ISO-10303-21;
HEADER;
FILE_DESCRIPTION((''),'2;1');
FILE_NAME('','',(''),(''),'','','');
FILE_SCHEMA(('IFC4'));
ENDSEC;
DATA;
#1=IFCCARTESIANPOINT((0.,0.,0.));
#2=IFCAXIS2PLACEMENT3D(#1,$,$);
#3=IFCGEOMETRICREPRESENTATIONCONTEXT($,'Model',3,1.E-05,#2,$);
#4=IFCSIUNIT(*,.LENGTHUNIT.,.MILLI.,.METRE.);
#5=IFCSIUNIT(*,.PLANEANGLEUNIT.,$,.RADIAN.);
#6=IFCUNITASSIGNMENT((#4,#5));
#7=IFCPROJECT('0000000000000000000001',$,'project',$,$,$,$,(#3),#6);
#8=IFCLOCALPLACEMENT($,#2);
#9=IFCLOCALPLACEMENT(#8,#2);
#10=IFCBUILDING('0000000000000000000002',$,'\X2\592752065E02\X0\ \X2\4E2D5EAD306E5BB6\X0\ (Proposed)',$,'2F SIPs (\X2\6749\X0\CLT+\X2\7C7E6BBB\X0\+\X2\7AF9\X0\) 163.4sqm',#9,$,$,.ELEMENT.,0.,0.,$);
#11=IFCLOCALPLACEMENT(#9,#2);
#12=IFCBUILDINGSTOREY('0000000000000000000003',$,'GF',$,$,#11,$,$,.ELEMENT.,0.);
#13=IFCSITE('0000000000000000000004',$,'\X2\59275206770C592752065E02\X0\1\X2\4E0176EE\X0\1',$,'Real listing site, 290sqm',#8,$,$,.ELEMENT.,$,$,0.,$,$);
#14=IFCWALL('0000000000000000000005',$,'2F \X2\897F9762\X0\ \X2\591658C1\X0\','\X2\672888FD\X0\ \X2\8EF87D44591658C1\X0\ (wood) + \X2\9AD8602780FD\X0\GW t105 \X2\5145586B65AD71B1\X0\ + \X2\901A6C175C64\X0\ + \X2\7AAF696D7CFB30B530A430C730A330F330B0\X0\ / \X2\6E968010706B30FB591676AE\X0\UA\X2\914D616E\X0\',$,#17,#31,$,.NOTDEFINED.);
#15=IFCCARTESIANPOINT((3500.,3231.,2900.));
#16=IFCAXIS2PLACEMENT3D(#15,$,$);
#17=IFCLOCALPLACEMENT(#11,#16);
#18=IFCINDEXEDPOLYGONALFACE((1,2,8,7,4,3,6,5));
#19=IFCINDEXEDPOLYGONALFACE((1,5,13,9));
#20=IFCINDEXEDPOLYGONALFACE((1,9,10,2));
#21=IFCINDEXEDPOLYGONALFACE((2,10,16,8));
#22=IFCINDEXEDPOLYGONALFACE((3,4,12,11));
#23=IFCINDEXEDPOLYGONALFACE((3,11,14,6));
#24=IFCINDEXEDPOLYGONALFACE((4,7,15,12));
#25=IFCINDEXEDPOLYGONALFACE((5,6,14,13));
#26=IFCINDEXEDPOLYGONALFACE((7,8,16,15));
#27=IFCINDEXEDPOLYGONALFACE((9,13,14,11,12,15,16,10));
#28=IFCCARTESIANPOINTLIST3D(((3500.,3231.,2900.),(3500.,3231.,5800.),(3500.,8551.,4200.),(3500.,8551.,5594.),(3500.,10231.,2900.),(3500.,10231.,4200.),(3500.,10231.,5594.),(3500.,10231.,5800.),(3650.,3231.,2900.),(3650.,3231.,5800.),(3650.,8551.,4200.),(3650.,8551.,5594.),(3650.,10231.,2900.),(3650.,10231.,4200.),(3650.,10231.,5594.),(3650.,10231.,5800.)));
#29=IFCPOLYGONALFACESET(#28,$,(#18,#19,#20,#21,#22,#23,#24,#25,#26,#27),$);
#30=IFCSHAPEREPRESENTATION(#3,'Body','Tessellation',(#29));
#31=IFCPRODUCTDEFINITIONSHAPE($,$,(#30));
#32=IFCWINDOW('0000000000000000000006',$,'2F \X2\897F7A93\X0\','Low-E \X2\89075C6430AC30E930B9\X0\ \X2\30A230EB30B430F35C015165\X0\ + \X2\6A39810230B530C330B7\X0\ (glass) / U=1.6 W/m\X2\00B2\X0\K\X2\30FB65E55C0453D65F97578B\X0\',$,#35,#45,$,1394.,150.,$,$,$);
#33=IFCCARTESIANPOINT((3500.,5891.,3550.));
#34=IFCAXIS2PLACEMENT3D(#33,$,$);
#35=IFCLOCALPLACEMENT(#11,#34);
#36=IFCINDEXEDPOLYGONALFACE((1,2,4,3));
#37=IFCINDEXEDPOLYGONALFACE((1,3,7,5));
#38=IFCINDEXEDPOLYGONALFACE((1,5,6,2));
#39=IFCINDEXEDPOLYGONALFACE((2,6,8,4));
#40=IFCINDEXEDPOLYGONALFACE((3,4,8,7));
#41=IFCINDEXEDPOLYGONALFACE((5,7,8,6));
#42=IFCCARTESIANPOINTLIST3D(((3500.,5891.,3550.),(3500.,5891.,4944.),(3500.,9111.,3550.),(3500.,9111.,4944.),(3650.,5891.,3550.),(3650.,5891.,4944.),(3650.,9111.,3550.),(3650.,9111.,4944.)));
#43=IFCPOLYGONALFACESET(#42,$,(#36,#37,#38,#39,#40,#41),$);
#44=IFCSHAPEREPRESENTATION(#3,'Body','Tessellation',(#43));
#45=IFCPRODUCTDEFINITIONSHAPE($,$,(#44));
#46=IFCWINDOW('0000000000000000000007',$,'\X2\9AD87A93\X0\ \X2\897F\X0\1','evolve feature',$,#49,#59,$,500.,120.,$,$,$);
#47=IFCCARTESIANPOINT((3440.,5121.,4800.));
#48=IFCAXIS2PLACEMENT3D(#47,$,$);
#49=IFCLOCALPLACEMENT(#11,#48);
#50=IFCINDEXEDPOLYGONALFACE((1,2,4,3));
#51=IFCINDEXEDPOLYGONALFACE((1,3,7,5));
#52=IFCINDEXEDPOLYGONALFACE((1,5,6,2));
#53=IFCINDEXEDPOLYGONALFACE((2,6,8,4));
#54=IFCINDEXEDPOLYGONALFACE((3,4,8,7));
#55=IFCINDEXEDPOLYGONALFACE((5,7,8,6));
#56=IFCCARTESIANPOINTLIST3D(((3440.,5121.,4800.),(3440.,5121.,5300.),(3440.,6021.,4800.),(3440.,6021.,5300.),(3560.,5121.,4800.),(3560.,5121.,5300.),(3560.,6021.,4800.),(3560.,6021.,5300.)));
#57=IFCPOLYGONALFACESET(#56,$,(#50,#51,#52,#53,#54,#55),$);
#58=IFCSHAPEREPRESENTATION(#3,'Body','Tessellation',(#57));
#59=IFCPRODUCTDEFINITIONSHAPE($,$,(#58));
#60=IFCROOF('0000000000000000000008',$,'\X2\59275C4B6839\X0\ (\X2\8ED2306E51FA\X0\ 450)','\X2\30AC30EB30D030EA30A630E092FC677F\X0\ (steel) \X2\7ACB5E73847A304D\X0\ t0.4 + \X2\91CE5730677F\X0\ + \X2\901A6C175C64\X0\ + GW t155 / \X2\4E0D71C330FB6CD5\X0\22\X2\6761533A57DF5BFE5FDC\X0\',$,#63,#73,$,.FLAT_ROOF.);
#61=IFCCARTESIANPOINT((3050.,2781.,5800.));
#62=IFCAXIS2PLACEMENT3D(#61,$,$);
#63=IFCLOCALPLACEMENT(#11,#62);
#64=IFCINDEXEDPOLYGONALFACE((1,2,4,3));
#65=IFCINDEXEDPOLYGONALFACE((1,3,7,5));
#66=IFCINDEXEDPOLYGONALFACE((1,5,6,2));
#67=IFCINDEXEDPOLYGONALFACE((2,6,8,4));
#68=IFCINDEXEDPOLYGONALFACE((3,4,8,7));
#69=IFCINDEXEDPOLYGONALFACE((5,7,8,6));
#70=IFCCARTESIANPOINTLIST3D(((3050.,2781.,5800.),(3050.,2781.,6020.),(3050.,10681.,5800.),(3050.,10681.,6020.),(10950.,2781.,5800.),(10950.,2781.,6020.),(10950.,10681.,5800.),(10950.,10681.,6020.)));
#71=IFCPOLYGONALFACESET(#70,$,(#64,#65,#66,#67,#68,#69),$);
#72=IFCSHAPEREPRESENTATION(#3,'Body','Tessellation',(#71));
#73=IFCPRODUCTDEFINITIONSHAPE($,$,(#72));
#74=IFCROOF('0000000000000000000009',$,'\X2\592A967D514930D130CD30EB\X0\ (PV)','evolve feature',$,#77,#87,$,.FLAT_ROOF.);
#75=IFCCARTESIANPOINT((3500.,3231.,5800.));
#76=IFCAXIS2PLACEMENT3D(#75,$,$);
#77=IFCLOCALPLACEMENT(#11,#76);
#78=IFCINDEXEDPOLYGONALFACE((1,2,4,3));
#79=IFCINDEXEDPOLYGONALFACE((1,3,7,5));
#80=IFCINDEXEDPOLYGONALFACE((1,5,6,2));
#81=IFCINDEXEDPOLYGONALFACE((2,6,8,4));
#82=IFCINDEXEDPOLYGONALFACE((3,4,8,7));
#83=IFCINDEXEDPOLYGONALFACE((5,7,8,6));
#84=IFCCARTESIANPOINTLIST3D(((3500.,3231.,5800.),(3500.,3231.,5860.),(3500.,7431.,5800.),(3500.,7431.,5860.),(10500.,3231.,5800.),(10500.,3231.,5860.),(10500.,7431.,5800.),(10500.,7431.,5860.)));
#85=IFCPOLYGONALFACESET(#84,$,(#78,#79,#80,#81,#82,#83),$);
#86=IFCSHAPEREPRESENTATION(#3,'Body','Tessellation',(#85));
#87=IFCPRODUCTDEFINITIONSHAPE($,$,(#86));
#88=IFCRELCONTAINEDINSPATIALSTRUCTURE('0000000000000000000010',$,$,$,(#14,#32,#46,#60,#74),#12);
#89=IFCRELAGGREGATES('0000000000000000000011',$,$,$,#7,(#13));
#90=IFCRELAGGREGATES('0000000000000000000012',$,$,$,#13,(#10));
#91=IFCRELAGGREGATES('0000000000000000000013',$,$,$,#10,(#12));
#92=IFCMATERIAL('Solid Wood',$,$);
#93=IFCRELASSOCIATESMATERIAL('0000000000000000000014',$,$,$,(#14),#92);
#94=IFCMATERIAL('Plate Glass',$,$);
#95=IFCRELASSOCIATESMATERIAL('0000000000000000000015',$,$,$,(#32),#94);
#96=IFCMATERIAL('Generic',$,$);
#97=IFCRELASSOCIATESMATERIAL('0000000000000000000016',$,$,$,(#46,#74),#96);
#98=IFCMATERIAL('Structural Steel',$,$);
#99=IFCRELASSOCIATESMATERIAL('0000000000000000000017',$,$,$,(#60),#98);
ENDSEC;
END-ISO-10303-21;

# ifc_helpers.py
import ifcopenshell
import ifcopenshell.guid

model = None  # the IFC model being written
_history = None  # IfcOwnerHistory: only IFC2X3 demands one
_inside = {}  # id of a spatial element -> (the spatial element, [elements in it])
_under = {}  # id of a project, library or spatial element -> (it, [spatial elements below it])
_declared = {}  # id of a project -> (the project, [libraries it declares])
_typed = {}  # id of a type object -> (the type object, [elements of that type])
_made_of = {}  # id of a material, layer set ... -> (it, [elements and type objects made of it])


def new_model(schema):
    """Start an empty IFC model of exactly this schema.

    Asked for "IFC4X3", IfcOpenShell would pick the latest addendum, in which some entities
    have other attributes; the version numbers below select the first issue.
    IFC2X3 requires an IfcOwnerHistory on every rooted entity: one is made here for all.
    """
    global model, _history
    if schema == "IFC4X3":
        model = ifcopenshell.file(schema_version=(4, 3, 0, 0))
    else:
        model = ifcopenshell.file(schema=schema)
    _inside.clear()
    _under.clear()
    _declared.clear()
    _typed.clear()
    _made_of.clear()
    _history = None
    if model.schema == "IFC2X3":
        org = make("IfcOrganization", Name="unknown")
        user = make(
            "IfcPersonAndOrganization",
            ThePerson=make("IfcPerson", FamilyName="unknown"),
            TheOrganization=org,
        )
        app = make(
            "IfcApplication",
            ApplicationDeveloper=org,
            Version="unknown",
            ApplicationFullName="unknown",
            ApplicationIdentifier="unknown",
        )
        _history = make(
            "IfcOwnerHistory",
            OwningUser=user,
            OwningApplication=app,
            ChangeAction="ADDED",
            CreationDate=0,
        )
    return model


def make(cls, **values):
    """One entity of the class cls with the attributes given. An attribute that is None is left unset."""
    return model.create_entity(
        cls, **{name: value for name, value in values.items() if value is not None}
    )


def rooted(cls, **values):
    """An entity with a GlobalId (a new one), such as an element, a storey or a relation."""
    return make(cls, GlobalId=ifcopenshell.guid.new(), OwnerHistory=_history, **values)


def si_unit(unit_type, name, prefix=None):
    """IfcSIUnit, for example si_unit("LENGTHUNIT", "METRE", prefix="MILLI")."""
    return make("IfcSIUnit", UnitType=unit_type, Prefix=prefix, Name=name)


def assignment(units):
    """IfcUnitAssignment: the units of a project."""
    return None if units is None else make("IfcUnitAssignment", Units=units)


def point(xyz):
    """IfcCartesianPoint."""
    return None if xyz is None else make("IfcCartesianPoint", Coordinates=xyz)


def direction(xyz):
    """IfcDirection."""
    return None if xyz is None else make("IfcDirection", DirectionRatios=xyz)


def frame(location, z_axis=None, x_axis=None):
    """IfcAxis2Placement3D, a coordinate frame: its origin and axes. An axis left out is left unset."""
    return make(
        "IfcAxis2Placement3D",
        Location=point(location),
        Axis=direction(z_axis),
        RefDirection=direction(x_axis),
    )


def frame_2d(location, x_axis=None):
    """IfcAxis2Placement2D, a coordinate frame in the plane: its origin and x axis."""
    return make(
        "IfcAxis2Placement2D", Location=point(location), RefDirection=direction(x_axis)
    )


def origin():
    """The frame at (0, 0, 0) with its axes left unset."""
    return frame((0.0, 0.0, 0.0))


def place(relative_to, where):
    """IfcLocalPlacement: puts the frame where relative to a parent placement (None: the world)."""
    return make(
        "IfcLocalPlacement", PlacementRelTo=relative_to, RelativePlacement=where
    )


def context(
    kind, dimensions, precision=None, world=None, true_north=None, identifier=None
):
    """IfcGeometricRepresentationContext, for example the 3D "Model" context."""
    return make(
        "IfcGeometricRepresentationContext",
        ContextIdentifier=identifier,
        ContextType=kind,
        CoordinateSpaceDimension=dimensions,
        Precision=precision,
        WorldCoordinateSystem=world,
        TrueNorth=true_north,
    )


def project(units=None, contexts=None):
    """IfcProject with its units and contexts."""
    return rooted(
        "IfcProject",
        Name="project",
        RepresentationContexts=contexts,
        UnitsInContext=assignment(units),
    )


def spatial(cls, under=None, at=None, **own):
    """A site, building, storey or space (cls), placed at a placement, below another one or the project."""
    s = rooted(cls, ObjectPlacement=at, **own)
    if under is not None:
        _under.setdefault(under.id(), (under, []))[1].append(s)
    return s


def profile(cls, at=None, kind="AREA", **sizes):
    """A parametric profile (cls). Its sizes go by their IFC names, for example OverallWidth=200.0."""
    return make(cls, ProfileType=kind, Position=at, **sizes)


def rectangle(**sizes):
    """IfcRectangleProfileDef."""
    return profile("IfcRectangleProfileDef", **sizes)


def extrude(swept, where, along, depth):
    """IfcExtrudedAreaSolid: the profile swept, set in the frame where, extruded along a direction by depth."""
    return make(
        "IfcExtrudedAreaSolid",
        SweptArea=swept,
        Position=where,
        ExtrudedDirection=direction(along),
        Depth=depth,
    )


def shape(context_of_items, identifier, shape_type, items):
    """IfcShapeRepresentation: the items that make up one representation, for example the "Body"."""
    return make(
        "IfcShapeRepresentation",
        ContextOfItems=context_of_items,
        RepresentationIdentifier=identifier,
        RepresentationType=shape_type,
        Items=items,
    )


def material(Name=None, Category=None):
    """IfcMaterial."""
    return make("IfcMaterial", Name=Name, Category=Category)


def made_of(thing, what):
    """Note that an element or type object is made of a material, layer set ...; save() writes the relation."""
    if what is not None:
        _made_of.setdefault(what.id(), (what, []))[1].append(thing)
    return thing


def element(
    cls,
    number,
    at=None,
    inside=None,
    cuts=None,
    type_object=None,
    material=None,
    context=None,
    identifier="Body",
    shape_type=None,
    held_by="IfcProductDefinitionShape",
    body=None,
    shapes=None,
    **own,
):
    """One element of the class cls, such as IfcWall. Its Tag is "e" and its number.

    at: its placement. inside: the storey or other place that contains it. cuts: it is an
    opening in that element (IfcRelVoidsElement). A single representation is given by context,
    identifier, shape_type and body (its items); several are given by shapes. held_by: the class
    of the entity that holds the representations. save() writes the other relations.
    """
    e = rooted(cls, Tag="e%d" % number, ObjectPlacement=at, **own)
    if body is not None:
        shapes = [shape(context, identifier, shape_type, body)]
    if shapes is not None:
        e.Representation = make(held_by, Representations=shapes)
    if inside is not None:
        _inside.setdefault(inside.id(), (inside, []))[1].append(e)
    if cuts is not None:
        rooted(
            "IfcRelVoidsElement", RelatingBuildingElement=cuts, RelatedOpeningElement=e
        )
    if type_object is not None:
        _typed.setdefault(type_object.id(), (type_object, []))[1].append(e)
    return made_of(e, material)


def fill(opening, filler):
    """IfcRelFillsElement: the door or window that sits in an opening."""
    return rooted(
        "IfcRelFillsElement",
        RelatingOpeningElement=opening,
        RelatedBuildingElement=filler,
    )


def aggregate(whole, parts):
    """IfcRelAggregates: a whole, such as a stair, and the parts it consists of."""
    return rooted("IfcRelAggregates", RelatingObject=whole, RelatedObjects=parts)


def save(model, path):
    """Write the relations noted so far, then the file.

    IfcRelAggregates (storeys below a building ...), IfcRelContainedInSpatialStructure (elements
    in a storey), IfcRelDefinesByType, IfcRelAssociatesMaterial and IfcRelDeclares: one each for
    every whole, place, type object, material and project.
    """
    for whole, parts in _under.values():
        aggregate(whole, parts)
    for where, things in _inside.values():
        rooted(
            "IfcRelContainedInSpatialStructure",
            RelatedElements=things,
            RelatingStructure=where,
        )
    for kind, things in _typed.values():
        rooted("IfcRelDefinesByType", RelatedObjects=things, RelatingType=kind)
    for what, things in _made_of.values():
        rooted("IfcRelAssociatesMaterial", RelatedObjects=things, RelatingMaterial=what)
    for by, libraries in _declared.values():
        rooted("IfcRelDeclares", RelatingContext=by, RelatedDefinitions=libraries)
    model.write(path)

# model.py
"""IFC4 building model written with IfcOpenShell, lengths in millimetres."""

from ifc_helpers import new_model, si_unit, frame, frame_2d, origin, place, context, project, spatial, rectangle, extrude, material, element, fill, save


model = new_model("IFC4")

# Units and contexts
model_context = context("Model", 3, precision=1e-05, world=origin())
ifc_project = project(units=[si_unit("LENGTHUNIT", "METRE", prefix="MILLI"), si_unit("PLANEANGLEUNIT", "RADIAN")], contexts=[model_context])

# Site, building, storey
site_placement = place(None, origin())
site = spatial("IfcSite", under=ifc_project, at=site_placement, Name="大分県大分市1丁目1", ObjectType="Real listing site, 290sqm", CompositionType="ELEMENT", RefElevation=0.0)
building_placement = place(site_placement, origin())
building = spatial("IfcBuilding", under=site, at=building_placement, Name="大分市 中庭の家 (Proposed)", ObjectType="2F SIPs (杉CLT+籾殻+竹) 163.4sqm", CompositionType="ELEMENT", ElevationOfRefHeight=0.0, ElevationOfTerrain=0.0)
storey_placement = place(building_placement, origin())
storey = spatial("IfcBuildingStorey", under=building, at=storey_placement, Name="GF", CompositionType="ELEMENT", Elevation=0.0)

# Shared definitions
ifc_material_1 = material(Name="Solid Wood")
ifc_material_2 = material(Name="Generic")

# Shared definitions
ifc_material_3 = material(Name="Plate Glass")

# Wall, openings, windows
wall_1_placement = place(storey_placement, frame((3500.0, 3231.0, 2900.0)))
wall_1 = element("IfcWall", 1, at=wall_1_placement, inside=storey, material=ifc_material_1, Name="2F 西面 外壁", Description="木製 軸組外壁 (wood) + 高性能GW t105 充填断熱 + 通気層 + 窯業系サイディング / 準耐火・外皮UA配慮", PredefinedType="NOTDEFINED", context=model_context, shape_type="SweptSolid", body=[
    extrude(rectangle(XDim=150.0, YDim=7000.0, at=frame_2d((75.0, 3500.0))), frame((3500.0, 3231.0, 2900.0)), (0.0, 0.0, 1.0), 2900.0),
])
opening_1_placement = place(storey_placement, frame((3500.0, 5891.0, 3550.0)))
opening_1 = element("IfcOpeningElement", 2, at=opening_1_placement, cuts=wall_1, PredefinedType="NOTDEFINED", context=model_context, shape_type="SweptSolid", body=[
    extrude(rectangle(XDim=150.0, YDim=3220.0, at=frame_2d((75.0, 1610.0))), frame((3500.0, 5891.0, 3550.0)), (0.0, 0.0, 1.0), 1394.0),
])
opening_2_placement = place(storey_placement, frame((3440.0, 5121.0, 4800.0)))
opening_2 = element("IfcOpeningElement", 3, at=opening_2_placement, cuts=wall_1, PredefinedType="NOTDEFINED", context=model_context, shape_type="SweptSolid", body=[
    extrude(rectangle(XDim=120.0, YDim=900.0, at=frame_2d((60.0, 450.0))), frame((3440.0, 5121.0, 4800.0)), (0.0, 0.0, 1.0), 500.0),
])
window_1_placement = place(storey_placement, frame((3500.0, 5891.0, 3550.0)))
window_1 = element("IfcWindow", 4, at=window_1_placement, inside=storey, material=ifc_material_3, Name="2F 西窓", Description="Low-E 複層ガラス アルゴン封入 + 樹脂サッシ (glass) / U=1.6 W/m²K・日射取得型", OverallHeight=1394.0, OverallWidth=150.0, context=model_context, shape_type="SweptSolid", body=[
    extrude(rectangle(XDim=150.0, YDim=3220.0, at=frame_2d((75.0, 1610.0))), frame((3500.0, 5891.0, 3550.0)), (0.0, 0.0, 1.0), 1394.0),
])
fill(opening_1, window_1)
window_2_placement = place(storey_placement, frame((3440.0, 5121.0, 4800.0)))
window_2 = element("IfcWindow", 5, at=window_2_placement, inside=storey, material=ifc_material_2, Name="高窓 西1", Description="evolve feature", OverallHeight=500.0, OverallWidth=120.0, context=model_context, shape_type="SweptSolid", body=[
    extrude(rectangle(XDim=120.0, YDim=900.0, at=frame_2d((60.0, 450.0))), frame((3440.0, 5121.0, 4800.0)), (0.0, 0.0, 1.0), 500.0),
])
fill(opening_2, window_2)

# Roofs
ifc_material_4 = material(Name="Structural Steel")
roof_1_placement = place(storey_placement, frame((3050.0, 2781.0, 5800.0)))
element("IfcRoof", 6, at=roof_1_placement, inside=storey, material=ifc_material_4, Name="大屋根 (軒の出 450)", Description="ガルバリウム鋼板 (steel) 立平葺き t0.4 + 野地板 + 通気層 + GW t155 / 不燃・法22条区域対応", PredefinedType="FLAT_ROOF", context=model_context, shape_type="SweptSolid", body=[
    extrude(rectangle(XDim=7900.0, YDim=7900.0, at=frame_2d((3950.0, 3950.0))), frame((3050.0, 2781.0, 5800.0)), (0.0, 0.0, 1.0), 220.0),
])
roof_2_placement = place(storey_placement, frame((3500.0, 3231.0, 5800.0)))
element("IfcRoof", 7, at=roof_2_placement, inside=storey, material=ifc_material_2, Name="太陽光パネル (PV)", Description="evolve feature", PredefinedType="FLAT_ROOF", context=model_context, shape_type="SweptSolid", body=[
    extrude(rectangle(XDim=7000.0, YDim=4200.0, at=frame_2d((3500.0, 2100.0))), frame((3500.0, 3231.0, 5800.0)), (0.0, 0.0, 1.0), 60.0),
])

save(model, "model.ifc")
